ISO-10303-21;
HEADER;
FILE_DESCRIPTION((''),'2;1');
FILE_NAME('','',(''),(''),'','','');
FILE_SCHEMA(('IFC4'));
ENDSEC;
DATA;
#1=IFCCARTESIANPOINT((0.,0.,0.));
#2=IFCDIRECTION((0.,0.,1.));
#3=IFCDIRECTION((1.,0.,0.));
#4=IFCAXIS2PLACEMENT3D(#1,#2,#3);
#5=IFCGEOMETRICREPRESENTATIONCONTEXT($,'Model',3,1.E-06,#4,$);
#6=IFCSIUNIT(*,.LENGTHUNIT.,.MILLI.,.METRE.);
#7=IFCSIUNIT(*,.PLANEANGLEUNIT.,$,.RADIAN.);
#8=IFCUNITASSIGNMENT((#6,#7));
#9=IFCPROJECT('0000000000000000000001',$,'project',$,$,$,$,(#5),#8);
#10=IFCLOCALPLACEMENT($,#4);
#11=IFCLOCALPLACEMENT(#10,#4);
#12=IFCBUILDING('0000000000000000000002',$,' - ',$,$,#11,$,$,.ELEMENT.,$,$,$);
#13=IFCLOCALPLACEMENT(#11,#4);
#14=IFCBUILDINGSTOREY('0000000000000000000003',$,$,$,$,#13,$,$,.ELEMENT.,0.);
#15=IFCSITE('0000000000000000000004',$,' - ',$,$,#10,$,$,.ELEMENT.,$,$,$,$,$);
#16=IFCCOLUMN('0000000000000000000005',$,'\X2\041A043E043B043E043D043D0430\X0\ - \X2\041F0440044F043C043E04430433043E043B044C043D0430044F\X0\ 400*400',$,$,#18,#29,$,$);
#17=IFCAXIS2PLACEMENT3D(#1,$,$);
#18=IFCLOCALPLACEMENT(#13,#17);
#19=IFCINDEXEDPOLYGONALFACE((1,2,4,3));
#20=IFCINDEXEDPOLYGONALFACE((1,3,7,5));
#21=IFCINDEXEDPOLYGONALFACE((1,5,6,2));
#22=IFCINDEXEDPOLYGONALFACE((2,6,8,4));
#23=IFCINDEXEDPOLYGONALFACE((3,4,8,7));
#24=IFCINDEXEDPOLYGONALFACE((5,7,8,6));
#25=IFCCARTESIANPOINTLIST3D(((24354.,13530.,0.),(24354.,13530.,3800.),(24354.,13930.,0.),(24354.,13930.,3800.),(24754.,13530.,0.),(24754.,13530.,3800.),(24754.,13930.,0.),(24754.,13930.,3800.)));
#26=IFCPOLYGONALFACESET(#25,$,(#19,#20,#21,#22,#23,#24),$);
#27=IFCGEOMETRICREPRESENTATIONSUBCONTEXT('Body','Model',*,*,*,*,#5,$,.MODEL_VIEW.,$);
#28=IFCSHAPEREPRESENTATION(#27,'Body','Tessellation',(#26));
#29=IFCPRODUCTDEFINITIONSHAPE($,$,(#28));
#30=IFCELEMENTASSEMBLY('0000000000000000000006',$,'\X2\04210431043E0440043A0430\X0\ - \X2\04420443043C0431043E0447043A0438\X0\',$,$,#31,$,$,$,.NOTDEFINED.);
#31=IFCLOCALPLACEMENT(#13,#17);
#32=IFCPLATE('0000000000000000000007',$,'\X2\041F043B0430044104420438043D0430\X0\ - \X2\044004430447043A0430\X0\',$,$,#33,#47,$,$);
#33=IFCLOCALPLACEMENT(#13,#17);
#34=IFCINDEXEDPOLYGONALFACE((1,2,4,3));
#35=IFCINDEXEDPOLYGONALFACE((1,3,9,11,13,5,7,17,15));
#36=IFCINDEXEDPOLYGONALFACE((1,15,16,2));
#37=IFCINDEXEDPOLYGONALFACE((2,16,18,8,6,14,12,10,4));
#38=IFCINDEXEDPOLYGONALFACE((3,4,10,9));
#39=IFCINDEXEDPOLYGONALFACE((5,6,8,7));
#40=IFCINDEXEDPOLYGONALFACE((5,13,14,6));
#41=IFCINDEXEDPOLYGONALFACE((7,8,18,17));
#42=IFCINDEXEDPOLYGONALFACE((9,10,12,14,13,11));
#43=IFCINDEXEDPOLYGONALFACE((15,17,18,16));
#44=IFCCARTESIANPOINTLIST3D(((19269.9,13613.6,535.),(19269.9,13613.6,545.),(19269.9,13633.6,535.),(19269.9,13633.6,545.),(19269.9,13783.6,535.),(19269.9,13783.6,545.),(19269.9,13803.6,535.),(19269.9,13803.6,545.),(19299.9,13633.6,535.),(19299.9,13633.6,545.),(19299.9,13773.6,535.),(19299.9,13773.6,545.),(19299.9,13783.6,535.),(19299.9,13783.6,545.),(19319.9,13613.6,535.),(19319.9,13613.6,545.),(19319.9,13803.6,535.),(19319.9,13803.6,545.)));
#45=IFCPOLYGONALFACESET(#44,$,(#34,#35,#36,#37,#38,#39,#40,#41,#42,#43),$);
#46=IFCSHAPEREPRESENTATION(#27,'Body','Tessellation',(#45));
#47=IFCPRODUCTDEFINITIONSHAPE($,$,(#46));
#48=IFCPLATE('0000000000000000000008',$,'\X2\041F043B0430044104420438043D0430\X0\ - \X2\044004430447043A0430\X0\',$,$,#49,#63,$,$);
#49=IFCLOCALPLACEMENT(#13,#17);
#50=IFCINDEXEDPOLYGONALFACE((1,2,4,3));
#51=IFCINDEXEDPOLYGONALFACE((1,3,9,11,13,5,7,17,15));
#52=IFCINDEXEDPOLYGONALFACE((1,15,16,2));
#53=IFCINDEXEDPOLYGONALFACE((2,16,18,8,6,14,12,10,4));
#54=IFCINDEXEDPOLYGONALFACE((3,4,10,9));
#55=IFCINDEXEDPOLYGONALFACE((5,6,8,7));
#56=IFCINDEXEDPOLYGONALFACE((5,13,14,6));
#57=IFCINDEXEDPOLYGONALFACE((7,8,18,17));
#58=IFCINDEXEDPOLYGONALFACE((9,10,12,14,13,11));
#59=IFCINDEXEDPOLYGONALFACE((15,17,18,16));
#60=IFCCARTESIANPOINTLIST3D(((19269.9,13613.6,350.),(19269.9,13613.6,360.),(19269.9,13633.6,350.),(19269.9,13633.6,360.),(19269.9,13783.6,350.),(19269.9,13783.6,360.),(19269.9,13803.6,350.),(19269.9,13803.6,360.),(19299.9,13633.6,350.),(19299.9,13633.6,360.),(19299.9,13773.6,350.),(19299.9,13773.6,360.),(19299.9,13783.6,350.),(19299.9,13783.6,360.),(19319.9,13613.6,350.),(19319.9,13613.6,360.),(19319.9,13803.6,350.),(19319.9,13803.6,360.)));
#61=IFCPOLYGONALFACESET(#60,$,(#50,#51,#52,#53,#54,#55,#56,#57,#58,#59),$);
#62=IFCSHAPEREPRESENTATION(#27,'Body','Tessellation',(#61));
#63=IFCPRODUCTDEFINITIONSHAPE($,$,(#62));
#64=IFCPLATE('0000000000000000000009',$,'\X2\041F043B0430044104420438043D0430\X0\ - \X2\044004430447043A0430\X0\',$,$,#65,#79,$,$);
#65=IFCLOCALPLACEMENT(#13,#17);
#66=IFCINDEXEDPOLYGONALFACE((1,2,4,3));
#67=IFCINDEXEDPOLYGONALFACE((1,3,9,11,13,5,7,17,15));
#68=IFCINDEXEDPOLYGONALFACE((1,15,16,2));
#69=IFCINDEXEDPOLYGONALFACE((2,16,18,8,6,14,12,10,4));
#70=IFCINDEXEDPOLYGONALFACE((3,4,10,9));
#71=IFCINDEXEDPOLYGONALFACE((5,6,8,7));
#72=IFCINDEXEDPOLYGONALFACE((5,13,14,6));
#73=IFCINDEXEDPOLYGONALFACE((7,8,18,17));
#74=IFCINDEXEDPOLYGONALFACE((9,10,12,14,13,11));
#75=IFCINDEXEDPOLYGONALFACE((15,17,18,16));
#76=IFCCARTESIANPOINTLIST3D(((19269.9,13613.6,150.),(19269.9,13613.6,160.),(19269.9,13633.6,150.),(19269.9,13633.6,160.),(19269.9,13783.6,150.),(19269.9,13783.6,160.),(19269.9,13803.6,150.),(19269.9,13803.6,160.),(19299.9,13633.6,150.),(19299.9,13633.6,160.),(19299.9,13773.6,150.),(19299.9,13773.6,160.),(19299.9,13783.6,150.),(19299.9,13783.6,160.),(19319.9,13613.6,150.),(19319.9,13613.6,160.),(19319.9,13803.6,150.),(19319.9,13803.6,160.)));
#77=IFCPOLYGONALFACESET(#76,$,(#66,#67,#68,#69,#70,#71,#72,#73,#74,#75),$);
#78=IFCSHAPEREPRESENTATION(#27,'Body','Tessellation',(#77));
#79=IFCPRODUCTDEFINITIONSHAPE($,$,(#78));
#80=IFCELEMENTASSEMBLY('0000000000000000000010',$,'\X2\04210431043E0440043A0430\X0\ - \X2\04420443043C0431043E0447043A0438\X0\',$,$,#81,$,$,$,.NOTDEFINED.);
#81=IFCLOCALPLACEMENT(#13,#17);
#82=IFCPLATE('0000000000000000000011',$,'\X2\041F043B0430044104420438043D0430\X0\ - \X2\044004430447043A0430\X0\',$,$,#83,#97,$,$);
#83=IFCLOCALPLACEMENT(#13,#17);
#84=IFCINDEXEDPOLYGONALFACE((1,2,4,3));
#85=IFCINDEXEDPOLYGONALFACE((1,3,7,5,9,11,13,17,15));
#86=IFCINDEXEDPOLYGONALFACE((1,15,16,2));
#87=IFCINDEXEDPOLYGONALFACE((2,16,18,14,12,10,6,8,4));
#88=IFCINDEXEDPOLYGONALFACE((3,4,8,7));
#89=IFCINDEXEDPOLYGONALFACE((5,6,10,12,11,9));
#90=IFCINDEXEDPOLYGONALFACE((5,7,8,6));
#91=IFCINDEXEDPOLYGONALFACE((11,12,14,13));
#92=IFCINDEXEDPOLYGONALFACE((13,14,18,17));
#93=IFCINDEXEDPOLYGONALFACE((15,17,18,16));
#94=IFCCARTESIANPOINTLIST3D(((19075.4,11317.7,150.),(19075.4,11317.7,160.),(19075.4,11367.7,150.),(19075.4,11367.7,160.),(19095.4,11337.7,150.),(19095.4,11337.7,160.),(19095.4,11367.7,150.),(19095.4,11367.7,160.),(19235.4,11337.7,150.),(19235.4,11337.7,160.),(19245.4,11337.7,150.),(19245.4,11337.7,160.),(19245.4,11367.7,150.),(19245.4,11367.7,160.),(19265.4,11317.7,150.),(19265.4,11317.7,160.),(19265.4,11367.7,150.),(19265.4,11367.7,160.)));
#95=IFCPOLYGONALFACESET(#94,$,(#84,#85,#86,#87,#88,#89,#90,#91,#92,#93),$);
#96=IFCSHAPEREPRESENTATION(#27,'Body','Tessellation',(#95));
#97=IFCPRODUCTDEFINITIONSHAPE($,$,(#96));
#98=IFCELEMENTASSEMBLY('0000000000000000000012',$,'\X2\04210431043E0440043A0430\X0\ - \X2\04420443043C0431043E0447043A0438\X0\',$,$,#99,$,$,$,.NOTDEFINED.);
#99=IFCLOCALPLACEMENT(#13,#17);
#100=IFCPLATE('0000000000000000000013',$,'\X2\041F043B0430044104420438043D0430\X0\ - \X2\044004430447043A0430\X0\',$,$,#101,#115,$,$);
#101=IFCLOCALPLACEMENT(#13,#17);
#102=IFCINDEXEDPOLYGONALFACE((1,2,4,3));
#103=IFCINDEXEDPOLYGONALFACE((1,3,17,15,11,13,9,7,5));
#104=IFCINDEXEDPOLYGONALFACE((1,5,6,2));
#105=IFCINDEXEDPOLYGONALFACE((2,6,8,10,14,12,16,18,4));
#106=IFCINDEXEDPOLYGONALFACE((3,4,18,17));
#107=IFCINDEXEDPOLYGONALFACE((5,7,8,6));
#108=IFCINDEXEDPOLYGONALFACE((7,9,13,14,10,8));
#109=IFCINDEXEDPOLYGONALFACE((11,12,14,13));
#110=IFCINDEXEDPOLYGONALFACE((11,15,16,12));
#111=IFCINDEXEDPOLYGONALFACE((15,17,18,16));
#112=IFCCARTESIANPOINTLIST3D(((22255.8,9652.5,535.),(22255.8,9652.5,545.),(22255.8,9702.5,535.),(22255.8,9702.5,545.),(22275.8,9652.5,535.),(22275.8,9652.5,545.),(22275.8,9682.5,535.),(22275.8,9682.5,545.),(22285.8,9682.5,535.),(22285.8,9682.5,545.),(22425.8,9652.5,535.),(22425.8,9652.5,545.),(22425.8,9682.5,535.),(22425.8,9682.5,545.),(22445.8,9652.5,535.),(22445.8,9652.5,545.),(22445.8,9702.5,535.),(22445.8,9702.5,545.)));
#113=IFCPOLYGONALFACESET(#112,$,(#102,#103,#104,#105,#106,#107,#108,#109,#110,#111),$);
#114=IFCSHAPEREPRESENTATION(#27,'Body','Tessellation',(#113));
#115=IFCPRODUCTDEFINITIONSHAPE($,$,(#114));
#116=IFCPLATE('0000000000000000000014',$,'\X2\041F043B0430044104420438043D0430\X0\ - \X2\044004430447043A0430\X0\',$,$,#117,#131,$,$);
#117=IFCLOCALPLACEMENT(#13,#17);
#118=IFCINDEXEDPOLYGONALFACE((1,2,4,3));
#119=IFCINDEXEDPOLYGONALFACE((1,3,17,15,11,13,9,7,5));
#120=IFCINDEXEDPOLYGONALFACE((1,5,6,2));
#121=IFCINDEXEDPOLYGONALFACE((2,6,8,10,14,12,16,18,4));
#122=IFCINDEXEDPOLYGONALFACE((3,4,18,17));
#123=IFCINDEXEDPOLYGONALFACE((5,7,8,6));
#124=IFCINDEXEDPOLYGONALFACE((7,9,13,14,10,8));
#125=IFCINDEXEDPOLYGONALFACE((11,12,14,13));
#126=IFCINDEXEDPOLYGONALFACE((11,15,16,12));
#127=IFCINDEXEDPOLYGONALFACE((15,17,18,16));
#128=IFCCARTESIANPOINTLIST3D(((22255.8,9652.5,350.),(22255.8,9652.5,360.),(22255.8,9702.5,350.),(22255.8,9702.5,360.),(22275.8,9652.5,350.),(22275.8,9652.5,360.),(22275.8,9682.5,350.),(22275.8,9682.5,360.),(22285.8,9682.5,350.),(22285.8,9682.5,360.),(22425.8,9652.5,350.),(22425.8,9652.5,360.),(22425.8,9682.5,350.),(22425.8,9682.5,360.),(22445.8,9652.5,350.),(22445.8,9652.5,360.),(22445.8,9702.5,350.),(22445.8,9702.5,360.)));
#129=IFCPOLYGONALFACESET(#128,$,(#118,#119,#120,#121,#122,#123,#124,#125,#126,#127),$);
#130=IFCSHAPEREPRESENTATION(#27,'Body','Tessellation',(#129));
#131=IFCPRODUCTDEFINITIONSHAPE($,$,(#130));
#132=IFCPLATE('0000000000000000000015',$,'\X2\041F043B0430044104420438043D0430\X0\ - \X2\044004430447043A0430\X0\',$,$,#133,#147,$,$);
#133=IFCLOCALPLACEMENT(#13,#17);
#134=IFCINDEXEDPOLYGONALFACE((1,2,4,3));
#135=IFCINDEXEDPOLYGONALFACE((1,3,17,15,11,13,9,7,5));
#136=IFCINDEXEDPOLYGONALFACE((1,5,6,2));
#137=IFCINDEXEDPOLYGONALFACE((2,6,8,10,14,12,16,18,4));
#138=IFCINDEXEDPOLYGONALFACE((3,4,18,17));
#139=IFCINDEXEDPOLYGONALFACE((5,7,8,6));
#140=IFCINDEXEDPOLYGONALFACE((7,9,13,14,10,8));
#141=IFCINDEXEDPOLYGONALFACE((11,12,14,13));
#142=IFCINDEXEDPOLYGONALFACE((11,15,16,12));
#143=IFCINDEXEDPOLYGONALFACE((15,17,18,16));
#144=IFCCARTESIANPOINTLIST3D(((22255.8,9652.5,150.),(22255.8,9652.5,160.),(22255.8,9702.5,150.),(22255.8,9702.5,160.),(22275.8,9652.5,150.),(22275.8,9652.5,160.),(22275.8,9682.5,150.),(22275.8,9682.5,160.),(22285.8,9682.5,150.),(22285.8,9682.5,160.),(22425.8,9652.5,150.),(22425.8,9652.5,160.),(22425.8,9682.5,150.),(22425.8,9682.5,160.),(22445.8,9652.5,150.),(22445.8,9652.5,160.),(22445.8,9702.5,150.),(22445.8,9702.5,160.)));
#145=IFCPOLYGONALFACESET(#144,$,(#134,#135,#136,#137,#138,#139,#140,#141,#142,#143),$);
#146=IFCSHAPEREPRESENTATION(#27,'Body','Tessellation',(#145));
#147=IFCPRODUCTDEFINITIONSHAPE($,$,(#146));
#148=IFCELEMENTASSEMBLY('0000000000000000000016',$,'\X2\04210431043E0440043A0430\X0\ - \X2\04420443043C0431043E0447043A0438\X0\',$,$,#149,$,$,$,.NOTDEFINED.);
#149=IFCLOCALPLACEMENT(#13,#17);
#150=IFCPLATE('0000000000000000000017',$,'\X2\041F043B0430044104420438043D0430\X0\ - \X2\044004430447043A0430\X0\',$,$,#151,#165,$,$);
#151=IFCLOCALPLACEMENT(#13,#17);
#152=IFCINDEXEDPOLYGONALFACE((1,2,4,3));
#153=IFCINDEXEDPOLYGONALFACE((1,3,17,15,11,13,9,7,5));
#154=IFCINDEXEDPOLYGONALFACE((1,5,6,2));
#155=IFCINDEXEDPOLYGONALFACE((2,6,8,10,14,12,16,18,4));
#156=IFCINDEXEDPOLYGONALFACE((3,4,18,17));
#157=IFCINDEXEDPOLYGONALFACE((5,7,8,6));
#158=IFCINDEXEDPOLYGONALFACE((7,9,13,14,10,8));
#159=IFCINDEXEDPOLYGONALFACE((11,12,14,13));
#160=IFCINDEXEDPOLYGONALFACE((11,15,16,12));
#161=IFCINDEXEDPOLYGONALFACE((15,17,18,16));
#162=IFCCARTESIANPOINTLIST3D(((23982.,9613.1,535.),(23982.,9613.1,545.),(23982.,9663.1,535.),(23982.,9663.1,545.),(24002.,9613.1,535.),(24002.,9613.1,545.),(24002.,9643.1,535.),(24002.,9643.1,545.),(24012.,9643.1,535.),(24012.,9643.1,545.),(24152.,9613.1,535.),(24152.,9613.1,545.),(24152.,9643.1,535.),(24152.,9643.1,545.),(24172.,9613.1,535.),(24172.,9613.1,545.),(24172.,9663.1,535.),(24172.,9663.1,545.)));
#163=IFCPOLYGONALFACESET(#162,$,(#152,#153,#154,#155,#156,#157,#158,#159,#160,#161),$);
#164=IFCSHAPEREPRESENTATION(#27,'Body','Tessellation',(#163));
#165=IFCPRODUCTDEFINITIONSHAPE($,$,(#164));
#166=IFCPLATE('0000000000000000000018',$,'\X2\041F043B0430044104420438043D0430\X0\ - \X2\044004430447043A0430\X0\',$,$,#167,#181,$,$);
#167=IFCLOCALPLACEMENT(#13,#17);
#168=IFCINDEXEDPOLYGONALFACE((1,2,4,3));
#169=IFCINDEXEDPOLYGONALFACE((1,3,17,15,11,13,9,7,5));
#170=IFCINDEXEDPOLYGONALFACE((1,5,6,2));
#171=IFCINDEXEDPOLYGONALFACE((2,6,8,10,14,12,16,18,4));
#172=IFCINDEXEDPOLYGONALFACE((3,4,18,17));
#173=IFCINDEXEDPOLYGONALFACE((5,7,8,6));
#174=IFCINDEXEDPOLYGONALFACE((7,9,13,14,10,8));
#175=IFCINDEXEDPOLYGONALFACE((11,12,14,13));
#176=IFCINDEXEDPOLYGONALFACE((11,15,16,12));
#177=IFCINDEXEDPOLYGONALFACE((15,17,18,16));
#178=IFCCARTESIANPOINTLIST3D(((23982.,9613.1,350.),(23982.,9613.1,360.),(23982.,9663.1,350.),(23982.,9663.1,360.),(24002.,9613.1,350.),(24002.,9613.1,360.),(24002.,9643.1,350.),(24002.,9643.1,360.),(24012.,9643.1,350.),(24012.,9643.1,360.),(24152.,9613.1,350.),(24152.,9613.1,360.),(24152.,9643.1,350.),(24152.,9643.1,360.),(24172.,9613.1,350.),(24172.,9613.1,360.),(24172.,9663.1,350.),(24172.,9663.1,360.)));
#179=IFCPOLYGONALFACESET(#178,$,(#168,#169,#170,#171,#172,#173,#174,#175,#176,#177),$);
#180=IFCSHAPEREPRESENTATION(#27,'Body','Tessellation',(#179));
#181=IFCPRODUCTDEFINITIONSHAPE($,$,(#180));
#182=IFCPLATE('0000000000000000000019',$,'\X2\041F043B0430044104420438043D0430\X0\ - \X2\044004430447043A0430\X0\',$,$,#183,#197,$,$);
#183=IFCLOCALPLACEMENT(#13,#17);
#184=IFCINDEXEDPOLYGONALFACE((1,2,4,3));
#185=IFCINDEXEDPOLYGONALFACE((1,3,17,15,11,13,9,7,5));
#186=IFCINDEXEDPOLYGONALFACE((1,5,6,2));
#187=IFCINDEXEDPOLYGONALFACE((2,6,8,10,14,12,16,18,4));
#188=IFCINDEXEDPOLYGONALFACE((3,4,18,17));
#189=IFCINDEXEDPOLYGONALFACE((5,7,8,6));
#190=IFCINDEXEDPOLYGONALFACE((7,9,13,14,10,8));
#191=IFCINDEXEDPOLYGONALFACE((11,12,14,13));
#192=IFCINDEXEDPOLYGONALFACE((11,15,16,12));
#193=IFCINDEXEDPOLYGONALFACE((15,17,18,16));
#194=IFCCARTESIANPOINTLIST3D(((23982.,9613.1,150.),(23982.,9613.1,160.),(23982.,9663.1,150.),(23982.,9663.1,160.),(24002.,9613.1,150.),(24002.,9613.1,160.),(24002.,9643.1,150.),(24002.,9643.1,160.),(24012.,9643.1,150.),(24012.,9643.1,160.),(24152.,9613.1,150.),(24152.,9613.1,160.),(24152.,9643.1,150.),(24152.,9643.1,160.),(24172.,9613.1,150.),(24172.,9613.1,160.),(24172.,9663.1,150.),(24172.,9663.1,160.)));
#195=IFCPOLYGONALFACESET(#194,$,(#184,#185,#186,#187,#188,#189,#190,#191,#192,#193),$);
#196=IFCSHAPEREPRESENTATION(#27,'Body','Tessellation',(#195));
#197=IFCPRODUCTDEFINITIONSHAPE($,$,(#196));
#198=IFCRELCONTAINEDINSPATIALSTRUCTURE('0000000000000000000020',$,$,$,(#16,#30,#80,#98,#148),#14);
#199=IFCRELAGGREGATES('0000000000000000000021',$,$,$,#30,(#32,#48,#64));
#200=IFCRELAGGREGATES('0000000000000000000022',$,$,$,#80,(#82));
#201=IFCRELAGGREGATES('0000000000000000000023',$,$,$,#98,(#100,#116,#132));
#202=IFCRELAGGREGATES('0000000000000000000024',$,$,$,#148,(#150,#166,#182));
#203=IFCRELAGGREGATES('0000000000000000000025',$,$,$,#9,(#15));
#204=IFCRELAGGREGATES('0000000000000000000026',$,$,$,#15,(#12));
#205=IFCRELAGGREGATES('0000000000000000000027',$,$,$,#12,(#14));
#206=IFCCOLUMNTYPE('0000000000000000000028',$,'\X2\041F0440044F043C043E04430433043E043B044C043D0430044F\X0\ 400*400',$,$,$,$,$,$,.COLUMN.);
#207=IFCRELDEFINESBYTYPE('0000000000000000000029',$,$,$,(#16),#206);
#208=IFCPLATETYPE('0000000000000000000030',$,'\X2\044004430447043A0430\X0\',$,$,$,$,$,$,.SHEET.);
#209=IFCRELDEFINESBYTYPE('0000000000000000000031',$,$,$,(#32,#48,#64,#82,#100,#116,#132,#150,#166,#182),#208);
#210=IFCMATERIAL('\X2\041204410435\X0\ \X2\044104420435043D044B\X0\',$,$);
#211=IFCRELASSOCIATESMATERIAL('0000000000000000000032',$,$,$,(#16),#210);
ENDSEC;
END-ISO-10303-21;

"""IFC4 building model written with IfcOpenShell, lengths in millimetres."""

from ifc_helpers import new_model, si_unit, frame, origin_with_axes, place, context, subcontext, project, spatial, line, indexed_curve, outline, extrude, source, transform, mapped, material, type_object, element, aggregate, save


model = new_model("IFC4")

# Units and contexts
model_context = context("Model", 3, precision=1e-06, world=origin_with_axes())
body_context = subcontext(model_context, "Body", "Model", "MODEL_VIEW")
ifc_project = project(units=[si_unit("LENGTHUNIT", "METRE", prefix="MILLI"), si_unit("PLANEANGLEUNIT", "RADIAN")], contexts=[model_context])

# Site, building, storey
site_placement = place(None, origin_with_axes())
site = spatial("IfcSite", under=ifc_project, at=site_placement, Name=" - ", CompositionType="ELEMENT")
building_placement = place(site_placement, origin_with_axes())
building = spatial("IfcBuilding", under=site, at=building_placement, Name=" - ", CompositionType="ELEMENT")
storey_placement = place(building_placement, origin_with_axes())
storey = spatial("IfcBuildingStorey", under=building, at=storey_placement, CompositionType="ELEMENT", Elevation=0.0)

# Column
ifc_material = material(Name="Все стены")
column_type = type_object("IfcColumnType", Name="Прямоугольная 400*400", PredefinedType="COLUMN")
shared_shape_1 = source(origin_with_axes(), body_context, "Body", "SweptSolid", [
    extrude(outline(indexed_curve([(-200.0, -200.0), (200.0, -200.0), (200.0, 200.0), (-200.0, 200.0)], segments=[line(1, 2), line(2, 3), line(3, 4), line(4, 1)])), origin_with_axes(), (0.0, 0.0, 1.0), 3800.0),
])
column_placement = place(storey_placement, frame((24554.0, 13730.0, 0.0), z_axis=(0.0, 0.0, 1.0), x_axis=(1.0, 0.0, 0.0)))
element("IfcColumn", 1, at=column_placement, inside=storey, type_object=column_type, material=ifc_material, Name="Колонна - Прямоугольная 400*400", context=body_context, shape_type="MappedRepresentation", body=[
    mapped(shared_shape_1, transform((0.0, 0.0, 0.0), x_axis=(1.0, 0.0, 0.0), y_axis=(0.0, 1.0, 0.0), z_axis=(0.0, 0.0, 1.0), scale=1.0)),
])

# Element assembly, plates
plate_type_1 = type_object("IfcPlateType", Name="ручка", PredefinedType="SHEET")
shared_shape_2 = source(origin_with_axes(), body_context, "Body", "SweptSolid", [
    extrude(outline(indexed_curve([(-95.0, -25.0), (-75.0, -25.0), (-75.0, 5.0), (-65.0, 5.0), (75.0, 5.0), (75.0, -25.0), (95.0, -25.0), (95.0, 25.0), (-95.0, 25.0)], segments=[line(1, 2), line(2, 3), line(3, 4), line(4, 5), line(5, 6), line(6, 7), line(7, 8), line(8, 9), line(9, 1)])), origin_with_axes(), (0.0, 0.0, 1.0), 10.0),
])
assembly_1_placement = place(storey_placement, frame((19269.9, 13508.6, 0.0), z_axis=(0.0, 0.0, 1.0), x_axis=(0.0, 1.0, 0.0)))
assembly_1 = element("IfcElementAssembly", 2, at=assembly_1_placement, inside=storey, Name="Сборка - тумбочки", PredefinedType="NOTDEFINED")
plate_1_placement = place(assembly_1_placement, frame((200.0, -25.0, 535.0), z_axis=(0.0, 0.0, 1.0), x_axis=(-1.0, 0.0, 0.0)))
plate_1 = element("IfcPlate", 3, at=plate_1_placement, type_object=plate_type_1, Name="Пластина - ручка", context=body_context, shape_type="MappedRepresentation", body=[
    mapped(shared_shape_2, transform((0.0, 0.0, 0.0), x_axis=(1.0, 0.0, 0.0), y_axis=(0.0, 1.0, 0.0), z_axis=(0.0, 0.0, 1.0), scale=1.0)),
])
plate_2_placement = place(assembly_1_placement, frame((200.0, -25.0, 350.0), z_axis=(0.0, 0.0, 1.0), x_axis=(-1.0, 0.0, 0.0)))
plate_2 = element("IfcPlate", 4, at=plate_2_placement, type_object=plate_type_1, Name="Пластина - ручка", context=body_context, shape_type="MappedRepresentation", body=[
    mapped(shared_shape_2, transform((0.0, 0.0, 0.0), x_axis=(1.0, 0.0, 0.0), y_axis=(0.0, 1.0, 0.0), z_axis=(0.0, 0.0, 1.0), scale=1.0)),
])
plate_3_placement = place(assembly_1_placement, frame((200.0, -25.0, 150.0), z_axis=(0.0, 0.0, 1.0), x_axis=(-1.0, 0.0, 0.0)))
plate_3 = element("IfcPlate", 5, at=plate_3_placement, type_object=plate_type_1, Name="Пластина - ручка", context=body_context, shape_type="MappedRepresentation", body=[
    mapped(shared_shape_2, transform((0.0, 0.0, 0.0), x_axis=(1.0, 0.0, 0.0), y_axis=(0.0, 1.0, 0.0), z_axis=(0.0, 0.0, 1.0), scale=1.0)),
])
aggregate(assembly_1, [plate_1, plate_2, plate_3])

# Element assembly, plate
assembly_2_placement = place(storey_placement, frame((18970.4, 11367.7, 0.0), z_axis=(0.0, 0.0, 1.0), x_axis=(1.0, 0.0, 0.0)))
assembly_2 = element("IfcElementAssembly", 6, at=assembly_2_placement, inside=storey, Name="Сборка - тумбочки", PredefinedType="NOTDEFINED")
plate_4_placement = place(assembly_2_placement, frame((200.0, -25.0, 150.0), z_axis=(0.0, 0.0, 1.0), x_axis=(-1.0, 0.0, 0.0)))
plate_4 = element("IfcPlate", 7, at=plate_4_placement, type_object=plate_type_1, Name="Пластина - ручка", context=body_context, shape_type="MappedRepresentation", body=[
    mapped(shared_shape_2, transform((0.0, 0.0, 0.0), x_axis=(1.0, 0.0, 0.0), y_axis=(0.0, 1.0, 0.0), z_axis=(0.0, 0.0, 1.0), scale=1.0)),
])
aggregate(assembly_2, [plate_4])

# Element assemblies, plates
assembly_3_placement = place(storey_placement, frame((22550.8, 9652.5, 0.0), z_axis=(0.0, 0.0, 1.0), x_axis=(-1.0, 0.0, 0.0)))
assembly_3 = element("IfcElementAssembly", 8, at=assembly_3_placement, inside=storey, Name="Сборка - тумбочки", PredefinedType="NOTDEFINED")
plate_5_placement = place(assembly_3_placement, frame((200.0, -25.0, 535.0), z_axis=(0.0, 0.0, 1.0), x_axis=(-1.0, 0.0, 0.0)))
plate_5 = element("IfcPlate", 9, at=plate_5_placement, type_object=plate_type_1, Name="Пластина - ручка", context=body_context, shape_type="MappedRepresentation", body=[
    mapped(shared_shape_2, transform((0.0, 0.0, 0.0), x_axis=(1.0, 0.0, 0.0), y_axis=(0.0, 1.0, 0.0), z_axis=(0.0, 0.0, 1.0), scale=1.0)),
])
plate_6_placement = place(assembly_3_placement, frame((200.0, -25.0, 350.0), z_axis=(0.0, 0.0, 1.0), x_axis=(-1.0, 0.0, 0.0)))
plate_6 = element("IfcPlate", 10, at=plate_6_placement, type_object=plate_type_1, Name="Пластина - ручка", context=body_context, shape_type="MappedRepresentation", body=[
    mapped(shared_shape_2, transform((0.0, 0.0, 0.0), x_axis=(1.0, 0.0, 0.0), y_axis=(0.0, 1.0, 0.0), z_axis=(0.0, 0.0, 1.0), scale=1.0)),
])
plate_7_placement = place(assembly_3_placement, frame((200.0, -25.0, 150.0), z_axis=(0.0, 0.0, 1.0), x_axis=(-1.0, 0.0, 0.0)))
plate_7 = element("IfcPlate", 11, at=plate_7_placement, type_object=plate_type_1, Name="Пластина - ручка", context=body_context, shape_type="MappedRepresentation", body=[
    mapped(shared_shape_2, transform((0.0, 0.0, 0.0), x_axis=(1.0, 0.0, 0.0), y_axis=(0.0, 1.0, 0.0), z_axis=(0.0, 0.0, 1.0), scale=1.0)),
])
aggregate(assembly_3, [plate_5, plate_6, plate_7])
assembly_4_placement = place(storey_placement, frame((24277.0, 9613.1, 0.0), z_axis=(0.0, 0.0, 1.0), x_axis=(-1.0, 0.0, 0.0)))
assembly_4 = element("IfcElementAssembly", 12, at=assembly_4_placement, inside=storey, Name="Сборка - тумбочки", PredefinedType="NOTDEFINED")
plate_8_placement = place(assembly_4_placement, frame((200.0, -25.0, 535.0), z_axis=(0.0, 0.0, 1.0), x_axis=(-1.0, 0.0, 0.0)))
plate_8 = element("IfcPlate", 13, at=plate_8_placement, type_object=plate_type_1, Name="Пластина - ручка", context=body_context, shape_type="MappedRepresentation", body=[
    mapped(shared_shape_2, transform((0.0, 0.0, 0.0), x_axis=(1.0, 0.0, 0.0), y_axis=(0.0, 1.0, 0.0), z_axis=(0.0, 0.0, 1.0), scale=1.0)),
])
plate_9_placement = place(assembly_4_placement, frame((200.0, -25.0, 350.0), z_axis=(0.0, 0.0, 1.0), x_axis=(-1.0, 0.0, 0.0)))
plate_9 = element("IfcPlate", 14, at=plate_9_placement, type_object=plate_type_1, Name="Пластина - ручка", context=body_context, shape_type="MappedRepresentation", body=[
    mapped(shared_shape_2, transform((0.0, 0.0, 0.0), x_axis=(1.0, 0.0, 0.0), y_axis=(0.0, 1.0, 0.0), z_axis=(0.0, 0.0, 1.0), scale=1.0)),
])
plate_10_placement = place(assembly_4_placement, frame((200.0, -25.0, 150.0), z_axis=(0.0, 0.0, 1.0), x_axis=(-1.0, 0.0, 0.0)))
plate_10 = element("IfcPlate", 15, at=plate_10_placement, type_object=plate_type_1, Name="Пластина - ручка", context=body_context, shape_type="MappedRepresentation", body=[
    mapped(shared_shape_2, transform((0.0, 0.0, 0.0), x_axis=(1.0, 0.0, 0.0), y_axis=(0.0, 1.0, 0.0), z_axis=(0.0, 0.0, 1.0), scale=1.0)),
])
aggregate(assembly_4, [plate_8, plate_9, plate_10])

save(model, "model.ifc")
